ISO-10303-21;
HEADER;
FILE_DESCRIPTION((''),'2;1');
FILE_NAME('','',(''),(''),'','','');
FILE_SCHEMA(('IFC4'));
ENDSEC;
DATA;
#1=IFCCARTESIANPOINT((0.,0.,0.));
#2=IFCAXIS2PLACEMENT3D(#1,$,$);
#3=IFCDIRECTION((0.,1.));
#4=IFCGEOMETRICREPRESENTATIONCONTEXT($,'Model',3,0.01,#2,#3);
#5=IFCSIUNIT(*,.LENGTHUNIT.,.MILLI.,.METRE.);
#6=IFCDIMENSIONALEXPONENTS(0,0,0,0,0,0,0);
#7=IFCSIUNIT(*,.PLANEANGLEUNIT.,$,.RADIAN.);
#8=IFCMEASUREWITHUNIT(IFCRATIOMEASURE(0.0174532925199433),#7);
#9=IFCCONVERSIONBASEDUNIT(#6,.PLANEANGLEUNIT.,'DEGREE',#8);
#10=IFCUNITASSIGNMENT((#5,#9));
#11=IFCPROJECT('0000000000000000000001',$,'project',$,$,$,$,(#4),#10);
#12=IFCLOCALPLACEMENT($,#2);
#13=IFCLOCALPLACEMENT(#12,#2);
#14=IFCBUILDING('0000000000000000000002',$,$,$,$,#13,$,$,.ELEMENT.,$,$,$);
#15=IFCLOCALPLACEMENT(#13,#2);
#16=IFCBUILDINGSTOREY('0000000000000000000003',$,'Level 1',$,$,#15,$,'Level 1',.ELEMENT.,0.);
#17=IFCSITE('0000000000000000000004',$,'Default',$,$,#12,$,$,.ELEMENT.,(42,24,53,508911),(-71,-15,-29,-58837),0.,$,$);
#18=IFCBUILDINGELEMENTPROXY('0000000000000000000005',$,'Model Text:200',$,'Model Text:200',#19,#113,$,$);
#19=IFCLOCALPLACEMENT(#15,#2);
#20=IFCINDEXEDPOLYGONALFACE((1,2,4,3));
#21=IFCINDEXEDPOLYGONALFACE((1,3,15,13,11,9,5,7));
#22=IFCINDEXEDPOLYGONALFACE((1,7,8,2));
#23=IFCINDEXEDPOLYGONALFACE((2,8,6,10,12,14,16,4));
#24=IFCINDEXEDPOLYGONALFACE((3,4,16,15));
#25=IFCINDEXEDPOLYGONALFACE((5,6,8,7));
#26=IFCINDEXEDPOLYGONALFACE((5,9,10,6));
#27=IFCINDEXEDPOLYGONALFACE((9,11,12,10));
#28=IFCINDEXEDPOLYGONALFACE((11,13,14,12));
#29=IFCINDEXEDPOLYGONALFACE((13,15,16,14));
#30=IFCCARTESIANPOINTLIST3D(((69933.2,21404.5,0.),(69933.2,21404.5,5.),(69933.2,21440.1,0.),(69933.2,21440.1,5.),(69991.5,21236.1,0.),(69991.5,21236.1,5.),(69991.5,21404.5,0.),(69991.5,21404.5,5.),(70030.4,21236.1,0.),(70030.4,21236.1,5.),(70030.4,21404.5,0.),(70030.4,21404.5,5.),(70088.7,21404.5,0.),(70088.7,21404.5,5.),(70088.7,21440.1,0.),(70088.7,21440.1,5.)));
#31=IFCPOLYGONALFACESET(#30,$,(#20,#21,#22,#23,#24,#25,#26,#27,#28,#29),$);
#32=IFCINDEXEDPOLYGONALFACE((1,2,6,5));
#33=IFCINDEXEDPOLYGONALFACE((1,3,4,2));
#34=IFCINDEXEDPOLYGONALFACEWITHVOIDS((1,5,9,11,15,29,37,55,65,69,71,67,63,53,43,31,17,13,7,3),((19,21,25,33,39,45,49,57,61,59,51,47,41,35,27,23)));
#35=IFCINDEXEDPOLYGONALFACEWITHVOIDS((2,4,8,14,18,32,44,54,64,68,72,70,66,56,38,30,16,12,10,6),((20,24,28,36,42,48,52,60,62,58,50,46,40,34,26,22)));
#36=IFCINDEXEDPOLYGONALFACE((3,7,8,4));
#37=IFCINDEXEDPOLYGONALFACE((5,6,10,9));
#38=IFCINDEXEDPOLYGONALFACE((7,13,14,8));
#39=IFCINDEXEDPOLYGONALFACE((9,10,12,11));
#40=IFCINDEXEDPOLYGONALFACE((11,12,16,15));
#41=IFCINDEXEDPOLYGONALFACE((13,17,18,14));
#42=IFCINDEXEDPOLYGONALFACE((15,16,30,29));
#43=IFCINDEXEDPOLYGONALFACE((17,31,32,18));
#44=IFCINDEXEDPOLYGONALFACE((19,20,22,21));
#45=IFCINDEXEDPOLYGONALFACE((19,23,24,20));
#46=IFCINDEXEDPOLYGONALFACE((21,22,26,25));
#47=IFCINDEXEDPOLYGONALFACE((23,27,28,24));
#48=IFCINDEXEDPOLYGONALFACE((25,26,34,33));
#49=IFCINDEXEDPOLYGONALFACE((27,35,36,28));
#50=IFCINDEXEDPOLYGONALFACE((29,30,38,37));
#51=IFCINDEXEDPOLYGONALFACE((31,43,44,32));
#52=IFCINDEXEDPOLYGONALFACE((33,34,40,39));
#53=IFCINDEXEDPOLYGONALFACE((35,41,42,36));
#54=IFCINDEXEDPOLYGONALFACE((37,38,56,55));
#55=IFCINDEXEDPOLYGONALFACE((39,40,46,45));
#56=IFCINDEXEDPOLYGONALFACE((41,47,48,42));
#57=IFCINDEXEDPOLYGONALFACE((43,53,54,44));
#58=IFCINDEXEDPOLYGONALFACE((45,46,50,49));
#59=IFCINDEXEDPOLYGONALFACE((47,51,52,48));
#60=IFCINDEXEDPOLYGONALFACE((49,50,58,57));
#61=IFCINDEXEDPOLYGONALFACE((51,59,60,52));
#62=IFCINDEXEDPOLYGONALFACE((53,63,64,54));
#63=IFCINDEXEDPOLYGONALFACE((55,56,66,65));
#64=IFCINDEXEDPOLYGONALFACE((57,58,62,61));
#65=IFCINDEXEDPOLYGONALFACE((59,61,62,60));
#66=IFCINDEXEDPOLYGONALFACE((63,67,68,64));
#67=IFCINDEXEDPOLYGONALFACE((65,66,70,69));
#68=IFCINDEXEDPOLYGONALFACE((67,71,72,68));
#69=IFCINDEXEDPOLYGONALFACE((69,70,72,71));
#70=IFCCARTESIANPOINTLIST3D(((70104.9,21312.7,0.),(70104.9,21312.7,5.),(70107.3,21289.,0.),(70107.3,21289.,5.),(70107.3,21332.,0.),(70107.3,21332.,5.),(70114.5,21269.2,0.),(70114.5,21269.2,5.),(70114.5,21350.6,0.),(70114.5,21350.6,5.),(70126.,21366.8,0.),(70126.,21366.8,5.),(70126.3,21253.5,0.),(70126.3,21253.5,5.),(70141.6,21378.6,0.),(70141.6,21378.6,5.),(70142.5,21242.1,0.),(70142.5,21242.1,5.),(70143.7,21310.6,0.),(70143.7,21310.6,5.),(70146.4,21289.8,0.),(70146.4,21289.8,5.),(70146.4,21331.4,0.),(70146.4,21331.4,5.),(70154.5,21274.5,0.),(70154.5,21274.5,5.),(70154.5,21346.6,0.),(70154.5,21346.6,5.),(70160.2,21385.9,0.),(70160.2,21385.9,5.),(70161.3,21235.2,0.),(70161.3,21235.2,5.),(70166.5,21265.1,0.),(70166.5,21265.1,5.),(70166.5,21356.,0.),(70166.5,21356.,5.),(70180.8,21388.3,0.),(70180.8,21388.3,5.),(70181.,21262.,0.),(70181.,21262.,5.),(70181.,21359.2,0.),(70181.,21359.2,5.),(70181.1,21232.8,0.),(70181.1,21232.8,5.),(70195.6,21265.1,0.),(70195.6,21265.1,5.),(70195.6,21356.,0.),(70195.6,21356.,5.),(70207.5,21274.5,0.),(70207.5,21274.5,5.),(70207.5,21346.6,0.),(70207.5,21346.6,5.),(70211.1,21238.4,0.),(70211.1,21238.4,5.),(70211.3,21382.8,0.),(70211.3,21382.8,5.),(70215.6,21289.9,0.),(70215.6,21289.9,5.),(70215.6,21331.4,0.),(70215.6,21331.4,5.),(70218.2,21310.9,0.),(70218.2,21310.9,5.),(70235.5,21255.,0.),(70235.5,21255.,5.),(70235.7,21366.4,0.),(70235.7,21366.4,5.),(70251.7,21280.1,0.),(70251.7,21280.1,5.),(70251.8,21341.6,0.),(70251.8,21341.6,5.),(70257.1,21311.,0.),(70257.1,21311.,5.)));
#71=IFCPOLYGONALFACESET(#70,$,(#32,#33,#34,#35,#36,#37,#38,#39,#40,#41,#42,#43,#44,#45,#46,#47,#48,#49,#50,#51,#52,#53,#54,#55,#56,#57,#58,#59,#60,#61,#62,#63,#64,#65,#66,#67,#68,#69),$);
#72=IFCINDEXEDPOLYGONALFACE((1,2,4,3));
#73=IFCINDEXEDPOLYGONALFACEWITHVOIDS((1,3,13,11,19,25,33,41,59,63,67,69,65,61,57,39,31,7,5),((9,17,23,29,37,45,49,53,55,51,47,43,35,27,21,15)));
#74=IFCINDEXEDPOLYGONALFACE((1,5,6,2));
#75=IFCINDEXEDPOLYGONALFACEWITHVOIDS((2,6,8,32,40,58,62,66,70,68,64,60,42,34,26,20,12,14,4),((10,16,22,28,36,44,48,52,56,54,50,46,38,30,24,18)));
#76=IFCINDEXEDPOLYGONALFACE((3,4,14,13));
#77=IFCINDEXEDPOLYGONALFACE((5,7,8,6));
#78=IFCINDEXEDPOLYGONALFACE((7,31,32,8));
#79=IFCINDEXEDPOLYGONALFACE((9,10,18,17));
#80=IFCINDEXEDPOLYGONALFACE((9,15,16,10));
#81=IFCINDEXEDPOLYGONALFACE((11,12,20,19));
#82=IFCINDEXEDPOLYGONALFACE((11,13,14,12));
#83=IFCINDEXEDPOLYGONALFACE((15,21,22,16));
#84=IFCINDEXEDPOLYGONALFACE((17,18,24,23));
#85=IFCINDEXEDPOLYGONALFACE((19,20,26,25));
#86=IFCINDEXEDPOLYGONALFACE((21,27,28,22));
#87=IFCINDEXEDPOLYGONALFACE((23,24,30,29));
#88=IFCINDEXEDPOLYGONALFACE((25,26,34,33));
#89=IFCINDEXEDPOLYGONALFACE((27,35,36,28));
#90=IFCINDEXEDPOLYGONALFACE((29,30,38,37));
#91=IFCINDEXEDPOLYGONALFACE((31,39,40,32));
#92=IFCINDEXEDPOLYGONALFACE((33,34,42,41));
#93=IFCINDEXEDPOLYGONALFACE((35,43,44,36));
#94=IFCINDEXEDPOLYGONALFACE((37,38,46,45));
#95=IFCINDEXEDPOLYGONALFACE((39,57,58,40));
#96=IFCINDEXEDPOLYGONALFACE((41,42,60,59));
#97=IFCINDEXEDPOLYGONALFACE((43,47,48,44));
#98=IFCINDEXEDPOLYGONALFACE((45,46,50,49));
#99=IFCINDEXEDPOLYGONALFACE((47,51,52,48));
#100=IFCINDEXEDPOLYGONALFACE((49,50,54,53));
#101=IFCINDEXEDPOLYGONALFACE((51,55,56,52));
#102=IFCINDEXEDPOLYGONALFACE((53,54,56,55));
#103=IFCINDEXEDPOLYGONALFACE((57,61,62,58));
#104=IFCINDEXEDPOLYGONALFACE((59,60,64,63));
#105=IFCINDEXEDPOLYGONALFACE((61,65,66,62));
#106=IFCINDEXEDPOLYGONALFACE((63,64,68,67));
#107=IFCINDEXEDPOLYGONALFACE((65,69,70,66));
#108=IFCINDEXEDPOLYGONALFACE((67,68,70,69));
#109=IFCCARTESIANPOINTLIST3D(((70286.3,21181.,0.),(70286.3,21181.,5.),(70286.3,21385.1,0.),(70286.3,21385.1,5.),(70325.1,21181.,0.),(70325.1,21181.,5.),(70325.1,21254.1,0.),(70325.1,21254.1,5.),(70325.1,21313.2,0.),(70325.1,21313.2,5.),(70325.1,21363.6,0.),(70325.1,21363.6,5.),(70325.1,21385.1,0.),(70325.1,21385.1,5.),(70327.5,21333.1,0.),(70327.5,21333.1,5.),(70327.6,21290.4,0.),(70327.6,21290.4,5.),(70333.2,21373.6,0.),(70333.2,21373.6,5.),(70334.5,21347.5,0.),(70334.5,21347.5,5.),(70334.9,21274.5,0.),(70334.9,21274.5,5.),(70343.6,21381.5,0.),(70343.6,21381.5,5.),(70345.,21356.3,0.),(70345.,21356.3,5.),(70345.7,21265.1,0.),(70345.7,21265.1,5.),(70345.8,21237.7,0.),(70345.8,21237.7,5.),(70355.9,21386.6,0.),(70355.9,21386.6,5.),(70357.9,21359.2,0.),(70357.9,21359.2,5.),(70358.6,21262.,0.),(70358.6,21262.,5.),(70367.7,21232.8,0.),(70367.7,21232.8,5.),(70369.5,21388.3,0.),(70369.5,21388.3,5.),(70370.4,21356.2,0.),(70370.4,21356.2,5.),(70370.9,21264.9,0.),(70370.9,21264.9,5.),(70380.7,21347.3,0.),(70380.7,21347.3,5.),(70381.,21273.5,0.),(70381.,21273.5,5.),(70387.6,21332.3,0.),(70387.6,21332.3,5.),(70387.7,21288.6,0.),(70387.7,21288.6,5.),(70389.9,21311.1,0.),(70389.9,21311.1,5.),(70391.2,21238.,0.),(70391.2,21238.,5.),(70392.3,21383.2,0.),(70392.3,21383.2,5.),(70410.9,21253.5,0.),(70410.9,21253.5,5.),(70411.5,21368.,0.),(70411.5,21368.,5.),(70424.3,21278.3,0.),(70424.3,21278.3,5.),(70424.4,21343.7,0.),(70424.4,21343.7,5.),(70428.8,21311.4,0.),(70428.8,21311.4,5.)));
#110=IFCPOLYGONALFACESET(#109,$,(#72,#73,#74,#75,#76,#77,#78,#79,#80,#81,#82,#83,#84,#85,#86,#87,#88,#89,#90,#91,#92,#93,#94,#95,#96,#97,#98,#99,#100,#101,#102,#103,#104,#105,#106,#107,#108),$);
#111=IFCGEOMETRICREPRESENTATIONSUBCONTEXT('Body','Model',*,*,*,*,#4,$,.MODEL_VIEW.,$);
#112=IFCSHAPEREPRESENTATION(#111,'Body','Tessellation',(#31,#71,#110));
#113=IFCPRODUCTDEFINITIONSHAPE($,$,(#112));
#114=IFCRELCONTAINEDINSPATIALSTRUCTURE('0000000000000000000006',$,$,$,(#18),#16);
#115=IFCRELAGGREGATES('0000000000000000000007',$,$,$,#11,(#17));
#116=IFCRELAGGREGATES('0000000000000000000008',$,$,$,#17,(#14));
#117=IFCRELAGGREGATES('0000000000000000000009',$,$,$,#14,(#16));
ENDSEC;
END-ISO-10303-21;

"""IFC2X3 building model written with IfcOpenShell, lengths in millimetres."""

from ifc_helpers import new_model, entity, si_unit, converted_unit, direction, frame, origin, place, context, subcontext, project, spatial, polyline, outline, extrude, element, save


model = new_model("IFC2X3")

# Units and contexts
model_context = context("Model", 3, precision=0.01, world=origin(), true_north=direction((0.0, 1.0)))
body_context = subcontext(model_context, "Body", "Model", "MODEL_VIEW")
ifc_project = project(units=[si_unit("LENGTHUNIT", "METRE", prefix="MILLI"), converted_unit("PLANEANGLEUNIT", "DEGREE", entity("IfcRatioMeasure", 0.0174532925199433), si_unit("PLANEANGLEUNIT", "RADIAN"), dimensions=[0, 0, 0, 0, 0, 0, 0])], contexts=[model_context])

# Site, building, storey
site_placement = place(None, origin())
site = spatial("IfcSite", under=ifc_project, at=site_placement, Name="Default", CompositionType="ELEMENT", RefLatitude=(42, 24, 53, 508911), RefLongitude=(-71, -15, -29, -58837), RefElevation=0.0)
building_placement = place(site_placement, origin())
building = spatial("IfcBuilding", under=site, at=building_placement, CompositionType="ELEMENT")
storey_placement = place(building_placement, origin())
storey = spatial("IfcBuildingStorey", under=building, at=storey_placement, Name="Level 1", LongName="Level 1", CompositionType="ELEMENT", Elevation=0.0)

# Building element proxy
proxy_1_placement = place(storey_placement, origin())
element("IfcBuildingElementProxy", 1, at=proxy_1_placement, inside=storey, Name="Model Text:200", ObjectType="Model Text:200", context=body_context, shape_type="SweptSolid", body=[
    extrude(outline(polyline([(-19.4, -135.2), (19.4, -135.2), (19.4, 33.2), (77.7, 33.2), (77.7, 68.8), (-77.7, 68.8), (-77.7, 33.2), (-19.4, 33.2), (-19.4, -135.2)])), frame((70010.9, 21371.3, 0.0)), (0.0, 0.0, 1.0), 5.0),
    extrude(outline(polyline([(-8.8, -65.7), (15.1, -65.7), (35.5, -60.5), (52.3, -50.4), (65.3, -35.4), (74.1, -17.3), (78.4, 2.1), (75.9, 32.5), (61.8, 58.5), (38.4, 77.1), (8.3, 85.6), (-22.7, 83.3), (-49.0, 69.9), (-67.8, 47.3), (-76.3, 17.5), (-76.0, -3.3), (-70.7, -22.5), (-60.5, -39.2), (-45.5, -52.3), (-27.7, -61.4), (-8.8, -65.7)]), holes=[polyline([(-2.7, -27.2), (-23.1, -22.5), (-37.5, -12.9), (-45.7, 0.0), (-47.3, 14.8), (-42.7, 28.9), (-32.2, 39.9), (-16.3, 46.3), (4.5, 46.9), (25.1, 42.1), (39.6, 32.6), (47.7, 19.7), (49.4, 5.0), (44.8, -9.2), (34.2, -20.2), (18.2, -26.7), (-2.7, -27.2)])]), frame((70171.1, 21310.6, 0.0), z_axis=(0.0, 0.0, 1.0), x_axis=(0.100608, -0.994926, 0.0)), (0.0, 0.0, 1.0), 5.0),
    extrude(outline(polyline([(-73.1, -75.4), (130.9, -75.4), (130.9, -36.6), (57.8, -36.6), (74.3, -15.9), (79.1, 6.0), (73.9, 29.5), (58.4, 49.2), (33.6, 62.6), (0.5, 67.1), (-31.8, 62.8), (-56.1, 49.8), (-71.3, 30.7), (-76.4, 7.8), (-74.7, -5.8), (-69.6, -18.1), (-61.7, -28.5), (-51.7, -36.6), (-73.1, -36.6), (-73.1, -75.4)]), holes=[polyline([(-1.2, -36.6), (-21.2, -34.2), (-35.6, -27.2), (-44.3, -16.7), (-47.2, -3.8), (-44.3, 8.7), (-35.4, 19.0), (-20.4, 25.9), (0.8, 28.2), (23.3, 26.0), (38.5, 19.3), (47.1, 9.2), (49.9, -3.1), (46.8, -16.0), (37.4, -26.8), (21.5, -34.1), (-1.2, -36.6)])]), frame((70361.7, 21311.9, 0.0), z_axis=(0.0, 0.0, 1.0), x_axis=(0.0, -1.0, 0.0)), (0.0, 0.0, 1.0), 5.0),
])

save(model, "model.ifc")
